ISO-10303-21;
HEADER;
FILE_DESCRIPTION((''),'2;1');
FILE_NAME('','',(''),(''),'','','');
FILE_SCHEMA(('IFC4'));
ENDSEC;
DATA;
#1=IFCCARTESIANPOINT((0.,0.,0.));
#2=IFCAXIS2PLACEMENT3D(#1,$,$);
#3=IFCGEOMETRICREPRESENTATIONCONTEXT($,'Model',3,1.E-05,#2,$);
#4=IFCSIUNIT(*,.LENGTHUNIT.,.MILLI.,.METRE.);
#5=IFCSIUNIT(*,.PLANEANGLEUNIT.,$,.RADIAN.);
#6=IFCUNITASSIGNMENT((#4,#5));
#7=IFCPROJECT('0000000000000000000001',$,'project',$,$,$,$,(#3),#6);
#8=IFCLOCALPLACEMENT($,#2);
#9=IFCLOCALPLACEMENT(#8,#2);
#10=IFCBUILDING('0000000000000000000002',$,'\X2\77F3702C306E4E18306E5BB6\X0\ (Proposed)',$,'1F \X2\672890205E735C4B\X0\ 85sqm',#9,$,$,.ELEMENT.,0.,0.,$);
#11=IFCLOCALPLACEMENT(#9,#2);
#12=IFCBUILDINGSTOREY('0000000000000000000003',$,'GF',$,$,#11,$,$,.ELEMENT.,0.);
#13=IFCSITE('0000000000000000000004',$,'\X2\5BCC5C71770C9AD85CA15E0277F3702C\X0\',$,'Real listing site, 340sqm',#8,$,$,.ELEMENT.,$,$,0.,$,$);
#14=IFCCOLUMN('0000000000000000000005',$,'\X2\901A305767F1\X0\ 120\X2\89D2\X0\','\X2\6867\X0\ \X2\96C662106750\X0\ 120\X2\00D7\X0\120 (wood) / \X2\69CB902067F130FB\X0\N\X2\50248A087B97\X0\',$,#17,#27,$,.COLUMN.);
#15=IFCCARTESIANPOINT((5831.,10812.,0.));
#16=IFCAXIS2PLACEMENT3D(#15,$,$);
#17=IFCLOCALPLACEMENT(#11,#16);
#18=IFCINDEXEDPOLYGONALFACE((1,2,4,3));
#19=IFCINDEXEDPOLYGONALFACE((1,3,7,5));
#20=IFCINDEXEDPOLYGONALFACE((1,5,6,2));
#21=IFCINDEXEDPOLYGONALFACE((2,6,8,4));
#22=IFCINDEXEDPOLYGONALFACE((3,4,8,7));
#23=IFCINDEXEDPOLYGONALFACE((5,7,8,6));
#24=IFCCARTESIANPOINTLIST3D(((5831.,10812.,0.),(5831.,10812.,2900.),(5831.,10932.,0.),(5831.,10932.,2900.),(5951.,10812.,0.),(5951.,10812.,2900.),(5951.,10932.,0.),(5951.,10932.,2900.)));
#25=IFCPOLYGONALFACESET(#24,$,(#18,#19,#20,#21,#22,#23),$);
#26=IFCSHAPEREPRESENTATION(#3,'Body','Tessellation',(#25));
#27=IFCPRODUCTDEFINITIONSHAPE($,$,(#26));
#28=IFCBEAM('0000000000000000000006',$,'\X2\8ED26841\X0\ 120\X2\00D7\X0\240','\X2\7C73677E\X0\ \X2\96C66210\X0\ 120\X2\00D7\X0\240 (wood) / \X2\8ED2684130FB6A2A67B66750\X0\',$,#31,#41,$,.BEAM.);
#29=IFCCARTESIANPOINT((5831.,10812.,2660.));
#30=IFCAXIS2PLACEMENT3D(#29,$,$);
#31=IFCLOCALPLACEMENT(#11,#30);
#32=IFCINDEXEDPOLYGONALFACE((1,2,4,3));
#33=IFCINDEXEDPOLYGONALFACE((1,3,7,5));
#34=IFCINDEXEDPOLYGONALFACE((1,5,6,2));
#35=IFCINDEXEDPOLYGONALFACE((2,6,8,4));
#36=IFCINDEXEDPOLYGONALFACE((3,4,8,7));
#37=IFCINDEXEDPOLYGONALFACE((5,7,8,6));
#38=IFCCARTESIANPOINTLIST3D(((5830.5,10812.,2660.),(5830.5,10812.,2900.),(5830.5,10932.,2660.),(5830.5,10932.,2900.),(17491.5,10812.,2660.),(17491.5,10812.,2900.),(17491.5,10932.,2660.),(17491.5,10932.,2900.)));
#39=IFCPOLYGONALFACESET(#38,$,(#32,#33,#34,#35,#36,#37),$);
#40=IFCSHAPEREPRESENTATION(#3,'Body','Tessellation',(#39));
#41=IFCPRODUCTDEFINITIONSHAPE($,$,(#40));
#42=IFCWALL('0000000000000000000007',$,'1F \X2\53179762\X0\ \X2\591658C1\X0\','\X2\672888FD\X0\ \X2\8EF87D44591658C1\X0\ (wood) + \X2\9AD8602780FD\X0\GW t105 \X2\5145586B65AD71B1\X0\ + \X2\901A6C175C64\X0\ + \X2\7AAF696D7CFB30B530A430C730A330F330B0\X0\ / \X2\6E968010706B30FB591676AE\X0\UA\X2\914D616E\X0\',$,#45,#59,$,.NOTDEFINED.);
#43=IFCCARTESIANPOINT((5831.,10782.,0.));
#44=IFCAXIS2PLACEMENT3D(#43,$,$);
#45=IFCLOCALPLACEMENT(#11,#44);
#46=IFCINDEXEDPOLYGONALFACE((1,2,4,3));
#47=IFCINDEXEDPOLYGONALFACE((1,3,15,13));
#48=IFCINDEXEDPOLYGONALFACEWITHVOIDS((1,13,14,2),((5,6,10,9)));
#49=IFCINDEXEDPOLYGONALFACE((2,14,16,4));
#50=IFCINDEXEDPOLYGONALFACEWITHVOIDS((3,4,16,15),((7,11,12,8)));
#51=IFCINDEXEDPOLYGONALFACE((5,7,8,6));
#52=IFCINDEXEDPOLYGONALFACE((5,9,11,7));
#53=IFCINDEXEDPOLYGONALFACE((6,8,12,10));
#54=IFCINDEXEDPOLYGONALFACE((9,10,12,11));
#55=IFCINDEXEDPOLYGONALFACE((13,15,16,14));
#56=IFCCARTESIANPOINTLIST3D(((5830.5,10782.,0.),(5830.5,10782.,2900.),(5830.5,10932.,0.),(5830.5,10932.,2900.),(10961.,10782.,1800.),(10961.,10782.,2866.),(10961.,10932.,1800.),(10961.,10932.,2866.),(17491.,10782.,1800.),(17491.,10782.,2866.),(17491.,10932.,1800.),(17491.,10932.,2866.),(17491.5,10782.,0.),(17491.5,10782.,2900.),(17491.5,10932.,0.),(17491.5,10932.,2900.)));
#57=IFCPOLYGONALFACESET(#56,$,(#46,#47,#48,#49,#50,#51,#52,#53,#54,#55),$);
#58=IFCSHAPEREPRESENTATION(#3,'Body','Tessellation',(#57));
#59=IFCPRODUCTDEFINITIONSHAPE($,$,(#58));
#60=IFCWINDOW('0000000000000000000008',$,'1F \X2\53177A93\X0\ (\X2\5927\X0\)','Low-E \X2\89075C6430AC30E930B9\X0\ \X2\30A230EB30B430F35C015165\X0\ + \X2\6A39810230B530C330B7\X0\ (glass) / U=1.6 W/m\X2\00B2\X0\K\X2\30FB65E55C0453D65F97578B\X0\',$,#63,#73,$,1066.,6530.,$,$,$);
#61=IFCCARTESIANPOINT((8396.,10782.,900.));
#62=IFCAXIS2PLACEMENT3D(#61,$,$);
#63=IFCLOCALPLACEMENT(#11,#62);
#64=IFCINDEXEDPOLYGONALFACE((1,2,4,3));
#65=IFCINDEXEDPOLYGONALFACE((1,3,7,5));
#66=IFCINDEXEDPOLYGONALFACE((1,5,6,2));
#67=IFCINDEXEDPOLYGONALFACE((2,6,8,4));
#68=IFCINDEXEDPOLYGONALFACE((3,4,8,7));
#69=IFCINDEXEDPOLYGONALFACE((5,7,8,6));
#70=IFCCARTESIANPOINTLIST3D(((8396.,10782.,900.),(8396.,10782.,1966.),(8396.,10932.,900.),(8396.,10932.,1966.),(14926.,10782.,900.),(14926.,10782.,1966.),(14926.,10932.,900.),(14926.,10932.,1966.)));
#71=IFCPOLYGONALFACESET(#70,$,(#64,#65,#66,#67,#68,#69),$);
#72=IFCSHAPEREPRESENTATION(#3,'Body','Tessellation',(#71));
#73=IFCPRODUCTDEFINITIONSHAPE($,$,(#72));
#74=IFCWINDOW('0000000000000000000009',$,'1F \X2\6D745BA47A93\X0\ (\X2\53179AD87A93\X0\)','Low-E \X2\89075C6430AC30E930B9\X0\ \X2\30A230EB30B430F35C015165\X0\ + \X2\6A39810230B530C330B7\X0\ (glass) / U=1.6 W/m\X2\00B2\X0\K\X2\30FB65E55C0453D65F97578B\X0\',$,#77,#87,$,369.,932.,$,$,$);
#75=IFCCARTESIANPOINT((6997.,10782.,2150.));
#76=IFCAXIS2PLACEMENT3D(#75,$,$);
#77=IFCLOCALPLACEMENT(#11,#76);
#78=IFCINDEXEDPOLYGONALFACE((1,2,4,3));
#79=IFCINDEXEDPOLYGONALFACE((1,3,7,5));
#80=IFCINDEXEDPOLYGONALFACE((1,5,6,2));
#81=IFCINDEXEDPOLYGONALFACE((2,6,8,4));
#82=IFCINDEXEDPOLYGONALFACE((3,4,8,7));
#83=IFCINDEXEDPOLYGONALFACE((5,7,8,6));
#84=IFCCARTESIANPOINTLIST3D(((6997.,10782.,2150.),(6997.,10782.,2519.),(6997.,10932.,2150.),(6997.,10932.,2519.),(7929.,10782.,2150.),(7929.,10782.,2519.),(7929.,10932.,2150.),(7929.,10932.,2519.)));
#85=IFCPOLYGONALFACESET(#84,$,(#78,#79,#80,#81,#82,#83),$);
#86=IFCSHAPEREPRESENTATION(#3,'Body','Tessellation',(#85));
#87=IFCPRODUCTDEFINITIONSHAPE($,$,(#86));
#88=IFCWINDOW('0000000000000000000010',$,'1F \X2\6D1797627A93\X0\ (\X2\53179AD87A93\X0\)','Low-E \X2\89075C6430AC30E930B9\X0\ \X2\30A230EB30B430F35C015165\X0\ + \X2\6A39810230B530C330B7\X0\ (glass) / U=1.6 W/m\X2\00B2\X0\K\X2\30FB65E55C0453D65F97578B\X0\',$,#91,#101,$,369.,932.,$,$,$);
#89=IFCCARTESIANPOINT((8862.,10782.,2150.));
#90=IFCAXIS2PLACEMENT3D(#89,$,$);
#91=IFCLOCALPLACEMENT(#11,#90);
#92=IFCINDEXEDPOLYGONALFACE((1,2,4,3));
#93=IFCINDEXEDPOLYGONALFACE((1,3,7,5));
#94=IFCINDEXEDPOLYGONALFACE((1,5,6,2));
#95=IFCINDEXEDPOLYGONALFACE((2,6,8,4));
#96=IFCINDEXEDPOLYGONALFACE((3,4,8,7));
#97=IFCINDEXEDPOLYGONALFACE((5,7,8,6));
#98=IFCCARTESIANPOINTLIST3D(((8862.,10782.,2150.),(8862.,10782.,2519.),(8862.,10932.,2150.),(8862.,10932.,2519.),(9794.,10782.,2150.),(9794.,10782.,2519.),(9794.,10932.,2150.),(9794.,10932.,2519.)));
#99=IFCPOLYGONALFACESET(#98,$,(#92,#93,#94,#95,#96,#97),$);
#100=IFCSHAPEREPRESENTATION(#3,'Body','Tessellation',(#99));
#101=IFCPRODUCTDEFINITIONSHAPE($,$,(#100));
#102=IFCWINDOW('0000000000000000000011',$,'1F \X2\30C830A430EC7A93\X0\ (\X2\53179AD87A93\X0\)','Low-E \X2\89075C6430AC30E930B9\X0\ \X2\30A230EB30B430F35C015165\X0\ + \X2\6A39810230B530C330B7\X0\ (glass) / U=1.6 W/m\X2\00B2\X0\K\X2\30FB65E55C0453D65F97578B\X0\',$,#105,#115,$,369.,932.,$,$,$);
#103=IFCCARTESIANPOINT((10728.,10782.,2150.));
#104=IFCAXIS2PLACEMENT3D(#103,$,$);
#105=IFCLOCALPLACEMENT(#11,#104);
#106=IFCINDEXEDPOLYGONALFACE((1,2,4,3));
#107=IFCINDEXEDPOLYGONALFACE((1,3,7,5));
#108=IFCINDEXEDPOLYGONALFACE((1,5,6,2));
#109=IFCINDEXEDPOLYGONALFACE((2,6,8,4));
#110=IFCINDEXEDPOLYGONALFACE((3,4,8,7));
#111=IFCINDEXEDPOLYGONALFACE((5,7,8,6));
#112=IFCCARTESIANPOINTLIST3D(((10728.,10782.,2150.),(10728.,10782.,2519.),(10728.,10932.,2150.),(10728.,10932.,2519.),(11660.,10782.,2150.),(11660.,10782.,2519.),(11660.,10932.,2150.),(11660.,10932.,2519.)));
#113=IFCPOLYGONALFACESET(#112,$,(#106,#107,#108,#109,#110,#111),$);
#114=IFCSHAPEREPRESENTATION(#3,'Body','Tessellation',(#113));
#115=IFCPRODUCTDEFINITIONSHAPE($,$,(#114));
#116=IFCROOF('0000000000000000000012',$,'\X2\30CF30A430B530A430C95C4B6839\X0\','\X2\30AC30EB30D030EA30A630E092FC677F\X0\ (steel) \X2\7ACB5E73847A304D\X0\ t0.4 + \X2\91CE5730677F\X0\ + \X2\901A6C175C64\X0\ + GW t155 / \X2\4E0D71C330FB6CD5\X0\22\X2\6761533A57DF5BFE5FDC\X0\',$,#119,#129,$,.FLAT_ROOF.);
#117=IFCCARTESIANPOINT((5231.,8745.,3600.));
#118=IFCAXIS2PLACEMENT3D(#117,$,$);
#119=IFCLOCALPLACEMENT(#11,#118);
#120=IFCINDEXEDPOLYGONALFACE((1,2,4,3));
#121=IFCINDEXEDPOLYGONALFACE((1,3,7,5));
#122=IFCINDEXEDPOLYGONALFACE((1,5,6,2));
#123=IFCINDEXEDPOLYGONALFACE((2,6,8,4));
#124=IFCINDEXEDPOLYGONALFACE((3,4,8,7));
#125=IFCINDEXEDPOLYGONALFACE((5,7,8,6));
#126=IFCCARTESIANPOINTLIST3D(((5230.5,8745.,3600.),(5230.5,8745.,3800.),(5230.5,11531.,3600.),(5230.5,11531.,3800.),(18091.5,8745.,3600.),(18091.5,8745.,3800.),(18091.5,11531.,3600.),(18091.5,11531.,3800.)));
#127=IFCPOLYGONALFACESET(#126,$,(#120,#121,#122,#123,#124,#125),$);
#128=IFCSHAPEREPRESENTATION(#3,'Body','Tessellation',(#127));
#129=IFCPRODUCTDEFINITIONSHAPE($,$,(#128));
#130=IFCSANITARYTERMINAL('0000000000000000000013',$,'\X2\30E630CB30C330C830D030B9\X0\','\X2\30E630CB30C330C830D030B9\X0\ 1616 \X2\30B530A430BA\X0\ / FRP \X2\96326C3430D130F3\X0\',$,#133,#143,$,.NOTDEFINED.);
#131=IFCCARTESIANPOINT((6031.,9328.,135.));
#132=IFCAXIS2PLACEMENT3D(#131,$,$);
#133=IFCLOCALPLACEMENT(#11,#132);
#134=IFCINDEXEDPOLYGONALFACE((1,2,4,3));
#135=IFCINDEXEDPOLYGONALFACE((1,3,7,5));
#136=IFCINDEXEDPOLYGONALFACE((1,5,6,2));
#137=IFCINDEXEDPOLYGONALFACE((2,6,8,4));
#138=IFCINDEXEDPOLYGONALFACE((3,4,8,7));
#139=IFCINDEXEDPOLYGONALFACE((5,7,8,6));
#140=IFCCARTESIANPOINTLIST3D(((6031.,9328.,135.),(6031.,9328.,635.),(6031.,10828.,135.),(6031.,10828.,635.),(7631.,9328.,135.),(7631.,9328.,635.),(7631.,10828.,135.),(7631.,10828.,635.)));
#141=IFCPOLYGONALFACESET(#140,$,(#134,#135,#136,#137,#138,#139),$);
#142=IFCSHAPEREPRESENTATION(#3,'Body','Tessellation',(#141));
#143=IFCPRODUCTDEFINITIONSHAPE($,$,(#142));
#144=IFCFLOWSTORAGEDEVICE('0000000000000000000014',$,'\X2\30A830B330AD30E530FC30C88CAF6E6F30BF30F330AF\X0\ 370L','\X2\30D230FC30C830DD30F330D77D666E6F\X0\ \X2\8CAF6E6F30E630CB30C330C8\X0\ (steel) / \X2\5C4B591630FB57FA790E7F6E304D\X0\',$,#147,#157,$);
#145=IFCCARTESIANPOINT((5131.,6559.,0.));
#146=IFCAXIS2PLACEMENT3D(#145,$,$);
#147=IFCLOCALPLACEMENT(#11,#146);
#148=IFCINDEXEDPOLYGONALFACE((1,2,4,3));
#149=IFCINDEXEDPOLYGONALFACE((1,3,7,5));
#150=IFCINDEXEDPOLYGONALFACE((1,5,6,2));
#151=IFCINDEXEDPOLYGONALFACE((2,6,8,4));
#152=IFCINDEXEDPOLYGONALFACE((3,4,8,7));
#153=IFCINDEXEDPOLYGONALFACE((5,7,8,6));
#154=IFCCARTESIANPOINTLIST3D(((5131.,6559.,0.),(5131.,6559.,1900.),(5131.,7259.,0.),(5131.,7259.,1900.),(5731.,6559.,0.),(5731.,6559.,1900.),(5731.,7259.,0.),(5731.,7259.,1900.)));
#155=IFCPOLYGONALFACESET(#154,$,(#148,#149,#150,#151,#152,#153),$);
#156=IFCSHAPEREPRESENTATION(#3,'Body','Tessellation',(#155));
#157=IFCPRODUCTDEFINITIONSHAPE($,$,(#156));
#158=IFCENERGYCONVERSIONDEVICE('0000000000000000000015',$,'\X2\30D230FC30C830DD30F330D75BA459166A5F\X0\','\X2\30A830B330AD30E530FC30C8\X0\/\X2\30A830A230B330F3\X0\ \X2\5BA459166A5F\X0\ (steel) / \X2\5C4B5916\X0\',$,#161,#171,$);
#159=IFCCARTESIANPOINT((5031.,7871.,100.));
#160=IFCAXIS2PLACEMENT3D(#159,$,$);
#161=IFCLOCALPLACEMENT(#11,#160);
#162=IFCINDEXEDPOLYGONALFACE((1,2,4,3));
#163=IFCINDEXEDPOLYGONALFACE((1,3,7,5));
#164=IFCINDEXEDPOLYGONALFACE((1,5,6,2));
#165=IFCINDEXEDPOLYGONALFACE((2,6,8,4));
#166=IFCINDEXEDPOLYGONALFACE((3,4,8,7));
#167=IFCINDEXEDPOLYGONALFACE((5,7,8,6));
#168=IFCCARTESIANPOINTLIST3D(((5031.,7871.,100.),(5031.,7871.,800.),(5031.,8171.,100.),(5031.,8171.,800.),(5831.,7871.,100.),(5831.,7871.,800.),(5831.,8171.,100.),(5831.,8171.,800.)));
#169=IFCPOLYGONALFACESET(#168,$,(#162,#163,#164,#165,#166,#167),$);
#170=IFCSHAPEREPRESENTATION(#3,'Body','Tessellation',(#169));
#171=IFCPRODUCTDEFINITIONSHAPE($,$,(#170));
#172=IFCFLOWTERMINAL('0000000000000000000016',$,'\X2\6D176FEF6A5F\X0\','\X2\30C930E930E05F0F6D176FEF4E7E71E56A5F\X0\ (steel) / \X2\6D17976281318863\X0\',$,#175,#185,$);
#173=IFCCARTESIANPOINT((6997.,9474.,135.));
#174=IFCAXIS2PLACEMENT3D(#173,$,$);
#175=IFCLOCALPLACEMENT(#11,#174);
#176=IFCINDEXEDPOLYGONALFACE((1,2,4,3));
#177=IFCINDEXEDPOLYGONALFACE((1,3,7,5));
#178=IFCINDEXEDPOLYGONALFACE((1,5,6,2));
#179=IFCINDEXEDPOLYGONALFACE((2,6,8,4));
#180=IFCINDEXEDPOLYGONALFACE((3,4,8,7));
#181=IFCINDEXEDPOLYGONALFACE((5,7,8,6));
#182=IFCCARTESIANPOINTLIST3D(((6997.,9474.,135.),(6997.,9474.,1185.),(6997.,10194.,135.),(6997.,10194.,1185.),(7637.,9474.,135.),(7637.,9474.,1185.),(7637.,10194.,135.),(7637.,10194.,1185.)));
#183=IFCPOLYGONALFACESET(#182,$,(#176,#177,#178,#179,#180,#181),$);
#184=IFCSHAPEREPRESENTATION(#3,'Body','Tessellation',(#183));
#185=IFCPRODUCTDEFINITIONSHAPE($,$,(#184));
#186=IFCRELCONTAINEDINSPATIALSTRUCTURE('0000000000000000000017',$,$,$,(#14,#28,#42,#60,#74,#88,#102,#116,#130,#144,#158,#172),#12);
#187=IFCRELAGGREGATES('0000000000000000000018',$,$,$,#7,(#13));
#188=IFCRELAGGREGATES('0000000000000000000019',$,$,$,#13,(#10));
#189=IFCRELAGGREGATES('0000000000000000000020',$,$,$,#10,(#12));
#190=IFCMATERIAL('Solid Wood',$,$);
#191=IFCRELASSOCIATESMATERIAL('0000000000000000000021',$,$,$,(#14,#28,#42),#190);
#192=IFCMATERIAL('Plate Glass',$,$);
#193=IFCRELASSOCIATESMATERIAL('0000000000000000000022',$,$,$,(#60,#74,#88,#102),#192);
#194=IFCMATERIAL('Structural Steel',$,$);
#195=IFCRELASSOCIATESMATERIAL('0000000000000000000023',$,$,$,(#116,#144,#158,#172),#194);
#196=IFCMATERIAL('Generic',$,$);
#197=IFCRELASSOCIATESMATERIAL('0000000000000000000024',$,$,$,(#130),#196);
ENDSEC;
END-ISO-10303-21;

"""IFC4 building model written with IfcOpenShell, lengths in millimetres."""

from ifc_helpers import new_model, si_unit, frame, frame_2d, origin, place, context, project, spatial, rectangle, extrude, material, element, fill, save


model = new_model("IFC4")

# Units and contexts
model_context = context("Model", 3, precision=1e-05, world=origin())
ifc_project = project(units=[si_unit("LENGTHUNIT", "METRE", prefix="MILLI"), si_unit("PLANEANGLEUNIT", "RADIAN")], contexts=[model_context])

# Site, building, storey
site_placement = place(None, origin())
site = spatial("IfcSite", under=ifc_project, at=site_placement, Name="富山県高岡市石瀬", ObjectType="Real listing site, 340sqm", CompositionType="ELEMENT", RefElevation=0.0)
building_placement = place(site_placement, origin())
building = spatial("IfcBuilding", under=site, at=building_placement, Name="石瀬の丘の家 (Proposed)", ObjectType="1F 木造平屋 85sqm", CompositionType="ELEMENT", ElevationOfRefHeight=0.0, ElevationOfTerrain=0.0)
storey_placement = place(building_placement, origin())
storey = spatial("IfcBuildingStorey", under=building, at=storey_placement, Name="GF", CompositionType="ELEMENT", Elevation=0.0)

# Column
ifc_material_1 = material(Name="Solid Wood")
column_1_placement = place(storey_placement, frame((5831.0, 10812.0, 0.0)))
element("IfcColumn", 1, at=column_1_placement, inside=storey, material=ifc_material_1, Name="通し柱 120角", Description="桧 集成材 120×120 (wood) / 構造柱・N値計算", PredefinedType="COLUMN", context=model_context, shape_type="SweptSolid", body=[
    extrude(rectangle(XDim=120.0, YDim=120.0, at=frame_2d((60.0, 60.0))), frame((5831.0, 10812.0, 0.0)), (0.0, 0.0, 1.0), 2900.0),
])

# Beam
beam_1_placement = place(storey_placement, frame((5831.0, 10812.0, 2660.0)))
element("IfcBeam", 2, at=beam_1_placement, inside=storey, material=ifc_material_1, Name="軒桁 120×240", Description="米松 集成 120×240 (wood) / 軒桁・横架材", PredefinedType="BEAM", context=model_context, shape_type="SweptSolid", body=[
    extrude(rectangle(XDim=11661.0, YDim=120.0, at=frame_2d((5830.0, 60.0))), frame((5831.0, 10812.0, 2660.0)), (0.0, 0.0, 1.0), 240.0),
])

# Wall, openings, windows
wall_1_placement = place(storey_placement, frame((5831.0, 10782.0, 0.0)))
wall_1 = element("IfcWall", 3, at=wall_1_placement, inside=storey, material=ifc_material_1, Name="1F 北面 外壁", Description="木製 軸組外壁 (wood) + 高性能GW t105 充填断熱 + 通気層 + 窯業系サイディング / 準耐火・外皮UA配慮", PredefinedType="NOTDEFINED", context=model_context, shape_type="SweptSolid", body=[
    extrude(rectangle(XDim=11661.0, YDim=150.0, at=frame_2d((5830.0, 75.0))), frame((5831.0, 10782.0, 0.0)), (0.0, 0.0, 1.0), 2900.0),
])
opening_1_placement = place(storey_placement, frame((8396.0, 10782.0, 900.0)))
opening_1 = element("IfcOpeningElement", 4, at=opening_1_placement, cuts=wall_1, PredefinedType="NOTDEFINED", context=model_context, shape_type="SweptSolid", body=[
    extrude(rectangle(XDim=6530.0, YDim=150.0, at=frame_2d((3265.0, 75.0))), frame((8396.0, 10782.0, 900.0)), (0.0, 0.0, 1.0), 1066.0),
])
opening_2_placement = place(storey_placement, frame((6997.0, 10782.0, 2150.0)))
opening_2 = element("IfcOpeningElement", 5, at=opening_2_placement, cuts=wall_1, PredefinedType="NOTDEFINED", context=model_context, shape_type="SweptSolid", body=[
    extrude(rectangle(XDim=932.0, YDim=150.0, at=frame_2d((466.0, 75.0))), frame((6997.0, 10782.0, 2150.0)), (0.0, 0.0, 1.0), 369.0),
])
opening_3_placement = place(storey_placement, frame((8862.0, 10782.0, 2150.0)))
opening_3 = element("IfcOpeningElement", 6, at=opening_3_placement, cuts=wall_1, PredefinedType="NOTDEFINED", context=model_context, shape_type="SweptSolid", body=[
    extrude(rectangle(XDim=932.0, YDim=150.0, at=frame_2d((466.0, 75.0))), frame((8862.0, 10782.0, 2150.0)), (0.0, 0.0, 1.0), 369.0),
])
opening_4_placement = place(storey_placement, frame((10728.0, 10782.0, 2150.0)))
opening_4 = element("IfcOpeningElement", 7, at=opening_4_placement, cuts=wall_1, PredefinedType="NOTDEFINED", context=model_context, shape_type="SweptSolid", body=[
    extrude(rectangle(XDim=932.0, YDim=150.0, at=frame_2d((466.0, 75.0))), frame((10728.0, 10782.0, 2150.0)), (0.0, 0.0, 1.0), 369.0),
])
ifc_material_2 = material(Name="Plate Glass")
window_1_placement = place(storey_placement, frame((8396.0, 10782.0, 900.0)))
window_1 = element("IfcWindow", 8, at=window_1_placement, inside=storey, material=ifc_material_2, Name="1F 北窓 (大)", Description="Low-E 複層ガラス アルゴン封入 + 樹脂サッシ (glass) / U=1.6 W/m²K・日射取得型", OverallHeight=1066.0, OverallWidth=6530.0, context=model_context, shape_type="SweptSolid", body=[
    extrude(rectangle(XDim=6530.0, YDim=150.0, at=frame_2d((3265.0, 75.0))), frame((8396.0, 10782.0, 900.0)), (0.0, 0.0, 1.0), 1066.0),
])
fill(opening_1, window_1)
window_2_placement = place(storey_placement, frame((6997.0, 10782.0, 2150.0)))
window_2 = element("IfcWindow", 9, at=window_2_placement, inside=storey, material=ifc_material_2, Name="1F 浴室窓 (北高窓)", Description="Low-E 複層ガラス アルゴン封入 + 樹脂サッシ (glass) / U=1.6 W/m²K・日射取得型", OverallHeight=369.0, OverallWidth=932.0, context=model_context, shape_type="SweptSolid", body=[
    extrude(rectangle(XDim=932.0, YDim=150.0, at=frame_2d((466.0, 75.0))), frame((6997.0, 10782.0, 2150.0)), (0.0, 0.0, 1.0), 369.0),
])
fill(opening_2, window_2)
window_3_placement = place(storey_placement, frame((8862.0, 10782.0, 2150.0)))
window_3 = element("IfcWindow", 10, at=window_3_placement, inside=storey, material=ifc_material_2, Name="1F 洗面窓 (北高窓)", Description="Low-E 複層ガラス アルゴン封入 + 樹脂サッシ (glass) / U=1.6 W/m²K・日射取得型", OverallHeight=369.0, OverallWidth=932.0, context=model_context, shape_type="SweptSolid", body=[
    extrude(rectangle(XDim=932.0, YDim=150.0, at=frame_2d((466.0, 75.0))), frame((8862.0, 10782.0, 2150.0)), (0.0, 0.0, 1.0), 369.0),
])
fill(opening_3, window_3)
window_4_placement = place(storey_placement, frame((10728.0, 10782.0, 2150.0)))
window_4 = element("IfcWindow", 11, at=window_4_placement, inside=storey, material=ifc_material_2, Name="1F トイレ窓 (北高窓)", Description="Low-E 複層ガラス アルゴン封入 + 樹脂サッシ (glass) / U=1.6 W/m²K・日射取得型", OverallHeight=369.0, OverallWidth=932.0, context=model_context, shape_type="SweptSolid", body=[
    extrude(rectangle(XDim=932.0, YDim=150.0, at=frame_2d((466.0, 75.0))), frame((10728.0, 10782.0, 2150.0)), (0.0, 0.0, 1.0), 369.0),
])
fill(opening_4, window_4)

# Roof
ifc_material_3 = material(Name="Structural Steel")
roof_placement = place(storey_placement, frame((5231.0, 8745.0, 3600.0)))
element("IfcRoof", 12, at=roof_placement, inside=storey, material=ifc_material_3, Name="ハイサイド屋根", Description="ガルバリウム鋼板 (steel) 立平葺き t0.4 + 野地板 + 通気層 + GW t155 / 不燃・法22条区域対応", PredefinedType="FLAT_ROOF", context=model_context, shape_type="SweptSolid", body=[
    extrude(rectangle(XDim=12861.0, YDim=2786.0, at=frame_2d((6430.0, 1393.0))), frame((5231.0, 8745.0, 3600.0)), (0.0, 0.0, 1.0), 200.0),
])

# Sanitary terminal
ifc_material_4 = material(Name="Generic")
sanitary_terminal_placement = place(storey_placement, frame((6031.0, 9328.0, 135.0)))
element("IfcSanitaryTerminal", 13, at=sanitary_terminal_placement, inside=storey, material=ifc_material_4, Name="ユニットバス", Description="ユニットバス 1616 サイズ / FRP 防水パン", PredefinedType="NOTDEFINED", context=model_context, shape_type="SweptSolid", body=[
    extrude(rectangle(XDim=1600.0, YDim=1500.0, at=frame_2d((800.0, 750.0))), frame((6031.0, 9328.0, 135.0)), (0.0, 0.0, 1.0), 500.0),
])

# Flow storage device
flow_storage_device_placement = place(storey_placement, frame((5131.0, 6559.0, 0.0)))
element("IfcFlowStorageDevice", 14, at=flow_storage_device_placement, inside=storey, material=ifc_material_3, Name="エコキュート貯湯タンク 370L", Description="ヒートポンプ給湯 貯湯ユニット (steel) / 屋外・基礎置き", context=model_context, shape_type="SweptSolid", body=[
    extrude(rectangle(XDim=600.0, YDim=700.0, at=frame_2d((300.0, 350.0))), frame((5131.0, 6559.0, 0.0)), (0.0, 0.0, 1.0), 1900.0),
])

# Energy conversion device
energy_conversion_device_placement = place(storey_placement, frame((5031.0, 7871.0, 100.0)))
element("IfcEnergyConversionDevice", 15, at=energy_conversion_device_placement, inside=storey, material=ifc_material_3, Name="ヒートポンプ室外機", Description="エコキュート/エアコン 室外機 (steel) / 屋外", context=model_context, shape_type="SweptSolid", body=[
    extrude(rectangle(XDim=800.0, YDim=300.0, at=frame_2d((400.0, 150.0))), frame((5031.0, 7871.0, 100.0)), (0.0, 0.0, 1.0), 700.0),
])

# Flow terminal
flow_terminal_placement = place(storey_placement, frame((6997.0, 9474.0, 135.0)))
element("IfcFlowTerminal", 16, at=flow_terminal_placement, inside=storey, material=ifc_material_3, Name="洗濯機", Description="ドラム式洗濯乾燥機 (steel) / 洗面脱衣", context=model_context, shape_type="SweptSolid", body=[
    extrude(rectangle(XDim=640.0, YDim=720.0, at=frame_2d((320.0, 360.0))), frame((6997.0, 9474.0, 135.0)), (0.0, 0.0, 1.0), 1050.0),
])

save(model, "model.ifc")
